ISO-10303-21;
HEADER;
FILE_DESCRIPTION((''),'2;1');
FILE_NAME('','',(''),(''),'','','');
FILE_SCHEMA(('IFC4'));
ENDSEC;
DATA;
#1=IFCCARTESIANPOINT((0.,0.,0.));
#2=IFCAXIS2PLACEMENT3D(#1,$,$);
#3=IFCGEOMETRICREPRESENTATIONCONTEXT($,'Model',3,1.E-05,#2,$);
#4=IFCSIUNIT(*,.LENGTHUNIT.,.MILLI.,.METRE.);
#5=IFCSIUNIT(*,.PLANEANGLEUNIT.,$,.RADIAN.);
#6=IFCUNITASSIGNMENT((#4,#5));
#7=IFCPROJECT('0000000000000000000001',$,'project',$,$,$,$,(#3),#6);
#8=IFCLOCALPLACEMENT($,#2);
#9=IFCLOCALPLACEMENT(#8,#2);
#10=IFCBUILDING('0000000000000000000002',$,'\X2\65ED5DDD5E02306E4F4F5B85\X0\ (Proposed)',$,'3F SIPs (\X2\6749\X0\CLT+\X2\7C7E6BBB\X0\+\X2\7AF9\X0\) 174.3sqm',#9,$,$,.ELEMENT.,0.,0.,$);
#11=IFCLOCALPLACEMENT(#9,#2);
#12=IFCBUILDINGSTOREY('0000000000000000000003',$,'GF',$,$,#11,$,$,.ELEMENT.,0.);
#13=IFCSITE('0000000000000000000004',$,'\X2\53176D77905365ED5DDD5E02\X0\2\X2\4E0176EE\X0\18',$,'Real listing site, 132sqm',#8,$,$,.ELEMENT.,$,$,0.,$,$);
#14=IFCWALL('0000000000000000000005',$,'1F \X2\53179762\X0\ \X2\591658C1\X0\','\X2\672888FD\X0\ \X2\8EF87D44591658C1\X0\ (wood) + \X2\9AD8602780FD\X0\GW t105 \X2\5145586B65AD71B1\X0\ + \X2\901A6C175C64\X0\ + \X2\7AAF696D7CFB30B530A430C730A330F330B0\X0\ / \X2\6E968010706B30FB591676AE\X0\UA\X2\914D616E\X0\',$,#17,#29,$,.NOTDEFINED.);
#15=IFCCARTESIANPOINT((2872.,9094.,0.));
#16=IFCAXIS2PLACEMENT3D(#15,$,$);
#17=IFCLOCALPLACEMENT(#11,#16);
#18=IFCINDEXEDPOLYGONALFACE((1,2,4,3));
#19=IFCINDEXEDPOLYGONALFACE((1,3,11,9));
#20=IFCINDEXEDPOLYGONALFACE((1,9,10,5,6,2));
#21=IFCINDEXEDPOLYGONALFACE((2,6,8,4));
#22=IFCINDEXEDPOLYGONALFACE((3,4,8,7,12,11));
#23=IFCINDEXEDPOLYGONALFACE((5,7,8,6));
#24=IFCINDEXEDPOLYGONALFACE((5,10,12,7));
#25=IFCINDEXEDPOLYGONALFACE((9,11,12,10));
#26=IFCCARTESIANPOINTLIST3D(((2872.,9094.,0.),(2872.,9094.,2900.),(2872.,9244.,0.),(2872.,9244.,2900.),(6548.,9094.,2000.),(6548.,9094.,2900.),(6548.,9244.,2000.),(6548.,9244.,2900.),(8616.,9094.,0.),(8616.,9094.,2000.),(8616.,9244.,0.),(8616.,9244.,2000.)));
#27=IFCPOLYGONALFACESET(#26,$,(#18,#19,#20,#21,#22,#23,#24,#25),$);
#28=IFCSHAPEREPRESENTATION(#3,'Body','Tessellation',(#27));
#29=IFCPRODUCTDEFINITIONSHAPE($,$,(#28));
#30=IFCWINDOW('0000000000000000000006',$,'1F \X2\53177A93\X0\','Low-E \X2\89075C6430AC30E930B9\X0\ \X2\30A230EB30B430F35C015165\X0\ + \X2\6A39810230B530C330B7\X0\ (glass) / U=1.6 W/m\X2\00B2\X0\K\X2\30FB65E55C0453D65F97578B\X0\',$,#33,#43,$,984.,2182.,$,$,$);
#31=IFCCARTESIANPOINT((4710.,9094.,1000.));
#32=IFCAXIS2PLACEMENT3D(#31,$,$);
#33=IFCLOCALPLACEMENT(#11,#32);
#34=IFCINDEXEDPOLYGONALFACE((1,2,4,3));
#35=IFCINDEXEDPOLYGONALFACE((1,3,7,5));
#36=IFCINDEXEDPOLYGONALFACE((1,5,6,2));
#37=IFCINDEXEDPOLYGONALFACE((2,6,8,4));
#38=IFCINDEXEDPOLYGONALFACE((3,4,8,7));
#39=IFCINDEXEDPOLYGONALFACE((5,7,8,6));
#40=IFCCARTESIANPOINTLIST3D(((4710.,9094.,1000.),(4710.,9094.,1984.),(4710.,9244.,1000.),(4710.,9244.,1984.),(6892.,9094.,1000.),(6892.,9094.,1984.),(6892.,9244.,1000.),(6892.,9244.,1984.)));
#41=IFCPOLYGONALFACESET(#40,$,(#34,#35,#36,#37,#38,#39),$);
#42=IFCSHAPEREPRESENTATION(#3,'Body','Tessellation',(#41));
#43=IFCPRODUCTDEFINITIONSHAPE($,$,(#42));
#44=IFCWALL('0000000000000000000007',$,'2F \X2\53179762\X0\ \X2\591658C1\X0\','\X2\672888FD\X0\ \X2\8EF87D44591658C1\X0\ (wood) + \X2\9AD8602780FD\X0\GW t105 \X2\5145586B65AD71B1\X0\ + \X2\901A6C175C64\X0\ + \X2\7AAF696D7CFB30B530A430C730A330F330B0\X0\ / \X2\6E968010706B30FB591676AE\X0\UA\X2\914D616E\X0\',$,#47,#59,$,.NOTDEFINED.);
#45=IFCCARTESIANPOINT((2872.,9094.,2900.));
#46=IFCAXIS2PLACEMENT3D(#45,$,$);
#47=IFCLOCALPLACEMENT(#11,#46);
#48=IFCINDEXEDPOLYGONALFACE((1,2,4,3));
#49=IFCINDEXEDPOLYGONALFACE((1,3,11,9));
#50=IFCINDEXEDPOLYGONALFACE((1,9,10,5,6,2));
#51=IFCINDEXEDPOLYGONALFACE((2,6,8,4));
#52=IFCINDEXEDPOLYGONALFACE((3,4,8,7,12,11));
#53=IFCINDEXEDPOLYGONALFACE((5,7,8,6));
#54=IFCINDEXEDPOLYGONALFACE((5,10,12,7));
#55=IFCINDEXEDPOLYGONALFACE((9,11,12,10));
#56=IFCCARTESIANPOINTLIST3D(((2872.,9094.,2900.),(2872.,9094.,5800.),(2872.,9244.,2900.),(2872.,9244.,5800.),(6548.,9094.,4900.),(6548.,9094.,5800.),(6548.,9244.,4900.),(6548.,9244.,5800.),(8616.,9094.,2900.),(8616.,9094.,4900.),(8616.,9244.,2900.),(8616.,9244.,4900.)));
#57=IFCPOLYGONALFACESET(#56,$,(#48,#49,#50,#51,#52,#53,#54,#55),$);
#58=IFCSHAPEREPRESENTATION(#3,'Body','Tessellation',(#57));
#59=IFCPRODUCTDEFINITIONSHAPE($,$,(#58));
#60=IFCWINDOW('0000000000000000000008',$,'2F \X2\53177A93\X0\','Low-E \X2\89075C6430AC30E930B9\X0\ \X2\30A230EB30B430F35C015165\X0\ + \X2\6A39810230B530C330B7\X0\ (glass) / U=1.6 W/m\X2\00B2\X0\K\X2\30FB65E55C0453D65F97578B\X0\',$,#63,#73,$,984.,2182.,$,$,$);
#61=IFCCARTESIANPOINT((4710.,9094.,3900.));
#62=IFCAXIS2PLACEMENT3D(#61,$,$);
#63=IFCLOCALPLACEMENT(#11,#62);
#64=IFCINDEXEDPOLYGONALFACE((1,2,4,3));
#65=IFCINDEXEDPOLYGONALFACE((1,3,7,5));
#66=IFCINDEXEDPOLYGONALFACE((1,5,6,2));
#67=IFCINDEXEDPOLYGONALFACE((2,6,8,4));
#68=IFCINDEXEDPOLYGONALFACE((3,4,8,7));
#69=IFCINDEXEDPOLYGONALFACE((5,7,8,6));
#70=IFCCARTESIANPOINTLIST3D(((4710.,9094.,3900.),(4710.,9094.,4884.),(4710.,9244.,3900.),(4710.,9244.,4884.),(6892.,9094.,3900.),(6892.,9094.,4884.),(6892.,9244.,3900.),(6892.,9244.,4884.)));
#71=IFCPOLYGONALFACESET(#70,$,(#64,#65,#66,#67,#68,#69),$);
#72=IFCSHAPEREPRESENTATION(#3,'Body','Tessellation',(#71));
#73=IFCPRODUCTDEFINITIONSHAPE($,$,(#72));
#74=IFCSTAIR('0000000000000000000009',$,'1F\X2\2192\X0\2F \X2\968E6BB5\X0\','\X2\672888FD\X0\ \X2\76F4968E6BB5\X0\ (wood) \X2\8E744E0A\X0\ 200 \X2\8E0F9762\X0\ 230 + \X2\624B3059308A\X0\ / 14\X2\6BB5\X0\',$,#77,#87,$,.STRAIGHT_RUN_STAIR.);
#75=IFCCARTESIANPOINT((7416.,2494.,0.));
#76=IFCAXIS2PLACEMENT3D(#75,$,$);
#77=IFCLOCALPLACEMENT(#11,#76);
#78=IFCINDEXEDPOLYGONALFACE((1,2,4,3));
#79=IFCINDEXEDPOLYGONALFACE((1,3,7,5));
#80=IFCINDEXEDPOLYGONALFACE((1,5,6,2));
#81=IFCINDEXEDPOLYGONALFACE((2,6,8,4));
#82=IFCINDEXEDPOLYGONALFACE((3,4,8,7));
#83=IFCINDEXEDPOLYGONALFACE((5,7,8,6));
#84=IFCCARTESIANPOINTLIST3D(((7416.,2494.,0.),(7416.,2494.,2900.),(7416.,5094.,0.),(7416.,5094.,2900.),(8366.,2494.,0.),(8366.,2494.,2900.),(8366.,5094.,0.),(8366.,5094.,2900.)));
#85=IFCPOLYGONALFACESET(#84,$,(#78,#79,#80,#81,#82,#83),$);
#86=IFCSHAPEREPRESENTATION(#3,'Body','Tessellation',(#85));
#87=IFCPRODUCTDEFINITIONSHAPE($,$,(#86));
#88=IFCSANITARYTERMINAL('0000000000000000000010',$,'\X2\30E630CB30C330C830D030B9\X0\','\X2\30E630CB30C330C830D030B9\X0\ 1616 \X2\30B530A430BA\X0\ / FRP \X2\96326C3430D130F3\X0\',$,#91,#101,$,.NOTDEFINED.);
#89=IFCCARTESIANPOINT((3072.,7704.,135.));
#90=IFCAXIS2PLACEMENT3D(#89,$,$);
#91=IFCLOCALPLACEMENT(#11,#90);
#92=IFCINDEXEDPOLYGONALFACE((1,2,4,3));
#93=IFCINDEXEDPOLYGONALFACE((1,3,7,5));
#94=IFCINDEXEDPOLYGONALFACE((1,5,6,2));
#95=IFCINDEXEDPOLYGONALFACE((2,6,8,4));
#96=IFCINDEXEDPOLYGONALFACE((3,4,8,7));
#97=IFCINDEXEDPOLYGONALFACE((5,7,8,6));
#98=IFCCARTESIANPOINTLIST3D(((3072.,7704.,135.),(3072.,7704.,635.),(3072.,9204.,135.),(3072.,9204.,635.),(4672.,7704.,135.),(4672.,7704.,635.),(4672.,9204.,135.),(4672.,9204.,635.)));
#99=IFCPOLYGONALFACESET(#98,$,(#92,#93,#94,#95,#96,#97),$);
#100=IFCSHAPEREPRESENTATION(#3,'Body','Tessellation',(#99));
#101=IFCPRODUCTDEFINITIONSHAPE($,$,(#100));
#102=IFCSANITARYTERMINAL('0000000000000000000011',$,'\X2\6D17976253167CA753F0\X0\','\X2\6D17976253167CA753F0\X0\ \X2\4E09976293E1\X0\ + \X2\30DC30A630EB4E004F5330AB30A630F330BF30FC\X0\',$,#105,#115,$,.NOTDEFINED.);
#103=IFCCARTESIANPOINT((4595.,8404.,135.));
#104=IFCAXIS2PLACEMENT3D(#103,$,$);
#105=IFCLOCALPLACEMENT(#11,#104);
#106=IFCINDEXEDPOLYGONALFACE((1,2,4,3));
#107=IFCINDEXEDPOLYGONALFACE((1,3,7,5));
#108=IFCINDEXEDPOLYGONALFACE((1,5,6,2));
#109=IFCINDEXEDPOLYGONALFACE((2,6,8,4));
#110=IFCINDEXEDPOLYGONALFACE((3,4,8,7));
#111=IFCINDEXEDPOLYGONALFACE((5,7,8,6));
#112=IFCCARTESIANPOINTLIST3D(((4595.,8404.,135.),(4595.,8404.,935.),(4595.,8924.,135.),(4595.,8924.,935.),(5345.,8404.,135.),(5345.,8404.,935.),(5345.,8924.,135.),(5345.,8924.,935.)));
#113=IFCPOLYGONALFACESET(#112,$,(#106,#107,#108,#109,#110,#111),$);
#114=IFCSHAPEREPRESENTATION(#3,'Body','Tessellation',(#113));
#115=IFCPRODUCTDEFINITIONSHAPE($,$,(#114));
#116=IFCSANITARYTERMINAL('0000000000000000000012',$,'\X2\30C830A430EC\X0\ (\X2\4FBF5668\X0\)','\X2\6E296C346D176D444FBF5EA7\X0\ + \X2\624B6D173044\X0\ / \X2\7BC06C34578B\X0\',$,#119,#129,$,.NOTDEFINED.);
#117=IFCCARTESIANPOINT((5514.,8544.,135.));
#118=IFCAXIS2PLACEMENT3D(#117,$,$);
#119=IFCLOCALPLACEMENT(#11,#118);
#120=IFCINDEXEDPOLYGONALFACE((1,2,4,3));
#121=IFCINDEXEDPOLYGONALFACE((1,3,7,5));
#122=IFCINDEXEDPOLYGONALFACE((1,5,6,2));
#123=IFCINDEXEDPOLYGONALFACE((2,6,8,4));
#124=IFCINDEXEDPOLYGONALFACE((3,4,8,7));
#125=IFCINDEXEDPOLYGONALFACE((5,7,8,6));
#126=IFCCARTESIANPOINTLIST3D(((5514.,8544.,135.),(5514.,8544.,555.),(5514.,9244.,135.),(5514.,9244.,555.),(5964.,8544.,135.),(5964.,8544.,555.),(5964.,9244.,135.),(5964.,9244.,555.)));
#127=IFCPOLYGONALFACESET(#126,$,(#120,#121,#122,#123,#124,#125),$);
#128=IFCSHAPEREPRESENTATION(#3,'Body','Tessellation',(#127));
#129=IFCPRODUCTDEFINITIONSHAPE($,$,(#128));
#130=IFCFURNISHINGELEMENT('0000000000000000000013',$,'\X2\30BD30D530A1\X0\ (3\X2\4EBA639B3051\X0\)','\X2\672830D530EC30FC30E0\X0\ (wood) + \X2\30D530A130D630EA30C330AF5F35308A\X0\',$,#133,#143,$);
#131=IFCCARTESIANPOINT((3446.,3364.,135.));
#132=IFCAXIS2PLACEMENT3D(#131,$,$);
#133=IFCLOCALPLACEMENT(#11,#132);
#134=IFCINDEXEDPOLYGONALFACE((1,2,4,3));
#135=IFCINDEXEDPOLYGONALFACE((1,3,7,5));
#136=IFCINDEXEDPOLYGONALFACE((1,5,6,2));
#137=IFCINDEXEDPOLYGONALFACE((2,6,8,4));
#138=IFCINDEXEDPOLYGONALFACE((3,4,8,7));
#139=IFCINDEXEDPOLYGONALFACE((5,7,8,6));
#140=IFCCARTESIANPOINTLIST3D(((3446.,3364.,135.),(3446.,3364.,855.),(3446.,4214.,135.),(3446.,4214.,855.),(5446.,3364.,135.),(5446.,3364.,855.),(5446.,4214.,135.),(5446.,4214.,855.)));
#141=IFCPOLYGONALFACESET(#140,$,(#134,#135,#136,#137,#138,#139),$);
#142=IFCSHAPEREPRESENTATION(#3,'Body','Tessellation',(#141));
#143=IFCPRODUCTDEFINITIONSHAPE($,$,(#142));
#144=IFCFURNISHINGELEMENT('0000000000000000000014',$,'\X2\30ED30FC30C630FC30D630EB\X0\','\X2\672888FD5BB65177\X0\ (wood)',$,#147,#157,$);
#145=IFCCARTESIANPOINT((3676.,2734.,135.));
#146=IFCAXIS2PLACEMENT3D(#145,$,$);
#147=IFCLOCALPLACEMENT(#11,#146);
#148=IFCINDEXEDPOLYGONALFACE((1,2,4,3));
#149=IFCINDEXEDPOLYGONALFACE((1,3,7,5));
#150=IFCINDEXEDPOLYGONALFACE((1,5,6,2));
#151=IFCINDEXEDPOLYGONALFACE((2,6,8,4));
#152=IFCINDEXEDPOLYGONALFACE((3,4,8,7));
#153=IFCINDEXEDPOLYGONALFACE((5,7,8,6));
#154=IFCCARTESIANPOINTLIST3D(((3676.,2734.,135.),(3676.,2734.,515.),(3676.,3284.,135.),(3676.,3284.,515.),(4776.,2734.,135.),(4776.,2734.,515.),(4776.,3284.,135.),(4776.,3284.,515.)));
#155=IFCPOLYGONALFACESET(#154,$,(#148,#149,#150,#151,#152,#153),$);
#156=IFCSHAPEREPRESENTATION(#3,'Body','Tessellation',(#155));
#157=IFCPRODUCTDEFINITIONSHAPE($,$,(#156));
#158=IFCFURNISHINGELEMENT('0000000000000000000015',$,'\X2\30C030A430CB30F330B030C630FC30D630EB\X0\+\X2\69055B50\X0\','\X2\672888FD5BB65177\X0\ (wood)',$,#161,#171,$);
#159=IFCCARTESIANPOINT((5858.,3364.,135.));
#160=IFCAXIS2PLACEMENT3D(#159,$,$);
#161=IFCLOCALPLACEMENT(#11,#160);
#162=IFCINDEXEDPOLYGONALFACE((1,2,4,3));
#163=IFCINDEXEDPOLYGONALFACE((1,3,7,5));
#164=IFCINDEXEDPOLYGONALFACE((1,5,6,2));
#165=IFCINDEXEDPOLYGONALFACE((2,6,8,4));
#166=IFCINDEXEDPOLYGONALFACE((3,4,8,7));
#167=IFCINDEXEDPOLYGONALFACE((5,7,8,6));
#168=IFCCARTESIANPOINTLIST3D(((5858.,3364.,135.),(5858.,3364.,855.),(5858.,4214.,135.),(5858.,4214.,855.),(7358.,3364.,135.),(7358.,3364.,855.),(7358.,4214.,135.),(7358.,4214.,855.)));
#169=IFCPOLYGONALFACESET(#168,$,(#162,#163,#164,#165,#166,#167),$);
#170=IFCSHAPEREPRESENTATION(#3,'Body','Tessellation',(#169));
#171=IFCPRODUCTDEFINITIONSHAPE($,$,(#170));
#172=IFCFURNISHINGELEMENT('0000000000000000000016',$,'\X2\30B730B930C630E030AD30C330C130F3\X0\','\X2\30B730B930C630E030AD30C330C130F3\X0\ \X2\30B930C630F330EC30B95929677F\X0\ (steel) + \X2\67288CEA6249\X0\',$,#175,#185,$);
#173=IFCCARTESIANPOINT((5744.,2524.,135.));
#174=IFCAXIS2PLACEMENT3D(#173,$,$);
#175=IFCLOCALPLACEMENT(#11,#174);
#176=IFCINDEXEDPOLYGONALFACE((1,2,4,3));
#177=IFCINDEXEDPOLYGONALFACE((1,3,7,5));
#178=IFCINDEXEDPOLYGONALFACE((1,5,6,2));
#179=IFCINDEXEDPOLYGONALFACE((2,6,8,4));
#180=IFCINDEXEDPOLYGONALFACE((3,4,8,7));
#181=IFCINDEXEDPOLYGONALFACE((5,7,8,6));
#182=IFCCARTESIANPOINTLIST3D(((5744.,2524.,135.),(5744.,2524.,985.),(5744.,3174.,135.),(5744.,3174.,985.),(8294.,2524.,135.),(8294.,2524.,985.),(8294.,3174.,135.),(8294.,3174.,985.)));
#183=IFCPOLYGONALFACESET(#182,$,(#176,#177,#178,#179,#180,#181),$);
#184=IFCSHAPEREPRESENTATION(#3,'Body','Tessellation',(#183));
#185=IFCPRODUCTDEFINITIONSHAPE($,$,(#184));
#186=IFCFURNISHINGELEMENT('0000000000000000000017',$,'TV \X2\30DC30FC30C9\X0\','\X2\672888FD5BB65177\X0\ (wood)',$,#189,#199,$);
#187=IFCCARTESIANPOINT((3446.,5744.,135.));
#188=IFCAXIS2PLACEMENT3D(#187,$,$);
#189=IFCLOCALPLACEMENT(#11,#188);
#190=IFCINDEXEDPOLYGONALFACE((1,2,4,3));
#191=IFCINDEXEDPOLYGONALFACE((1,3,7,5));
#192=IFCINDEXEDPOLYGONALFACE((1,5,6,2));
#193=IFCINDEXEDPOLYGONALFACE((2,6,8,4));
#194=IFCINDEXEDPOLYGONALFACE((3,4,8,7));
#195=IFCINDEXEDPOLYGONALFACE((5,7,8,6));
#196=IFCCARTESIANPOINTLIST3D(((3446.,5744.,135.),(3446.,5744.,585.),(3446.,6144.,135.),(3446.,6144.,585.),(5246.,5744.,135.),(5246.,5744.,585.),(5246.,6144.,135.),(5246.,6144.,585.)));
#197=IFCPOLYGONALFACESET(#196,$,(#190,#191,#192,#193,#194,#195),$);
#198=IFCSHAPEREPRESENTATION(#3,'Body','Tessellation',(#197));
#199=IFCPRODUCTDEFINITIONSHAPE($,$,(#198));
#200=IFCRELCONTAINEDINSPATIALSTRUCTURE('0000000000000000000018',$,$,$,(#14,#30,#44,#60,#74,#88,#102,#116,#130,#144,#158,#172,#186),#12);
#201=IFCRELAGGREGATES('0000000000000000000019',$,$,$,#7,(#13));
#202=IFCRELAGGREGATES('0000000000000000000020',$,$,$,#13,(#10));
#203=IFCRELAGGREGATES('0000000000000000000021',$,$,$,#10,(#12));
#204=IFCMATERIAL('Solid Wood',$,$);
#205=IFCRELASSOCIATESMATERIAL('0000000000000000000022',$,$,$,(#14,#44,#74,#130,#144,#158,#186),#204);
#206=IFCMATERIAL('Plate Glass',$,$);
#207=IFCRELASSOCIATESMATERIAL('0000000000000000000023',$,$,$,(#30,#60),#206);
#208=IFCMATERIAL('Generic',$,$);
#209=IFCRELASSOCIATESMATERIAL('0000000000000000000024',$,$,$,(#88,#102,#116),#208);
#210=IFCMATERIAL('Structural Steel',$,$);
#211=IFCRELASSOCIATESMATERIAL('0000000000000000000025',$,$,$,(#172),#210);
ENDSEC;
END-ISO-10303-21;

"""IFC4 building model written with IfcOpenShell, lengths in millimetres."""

from ifc_helpers import new_model, si_unit, frame, frame_2d, origin, place, context, project, spatial, rectangle, extrude, material, element, fill, save


model = new_model("IFC4")

# Units and contexts
model_context = context("Model", 3, precision=1e-05, world=origin())
ifc_project = project(units=[si_unit("LENGTHUNIT", "METRE", prefix="MILLI"), si_unit("PLANEANGLEUNIT", "RADIAN")], contexts=[model_context])

# Site, building, storey
site_placement = place(None, origin())
site = spatial("IfcSite", under=ifc_project, at=site_placement, Name="北海道旭川市2丁目18", ObjectType="Real listing site, 132sqm", CompositionType="ELEMENT", RefElevation=0.0)
building_placement = place(site_placement, origin())
building = spatial("IfcBuilding", under=site, at=building_placement, Name="旭川市の住宅 (Proposed)", ObjectType="3F SIPs (杉CLT+籾殻+竹) 174.3sqm", CompositionType="ELEMENT", ElevationOfRefHeight=0.0, ElevationOfTerrain=0.0)
storey_placement = place(building_placement, origin())
storey = spatial("IfcBuildingStorey", under=building, at=storey_placement, Name="GF", CompositionType="ELEMENT", Elevation=0.0)

# Wall, opening, window
ifc_material_1 = material(Name="Solid Wood")
wall_1_placement = place(storey_placement, frame((2872.0, 9094.0, 0.0)))
wall_1 = element("IfcWall", 1, at=wall_1_placement, inside=storey, material=ifc_material_1, Name="1F 北面 外壁", Description="木製 軸組外壁 (wood) + 高性能GW t105 充填断熱 + 通気層 + 窯業系サイディング / 準耐火・外皮UA配慮", PredefinedType="NOTDEFINED", context=model_context, shape_type="SweptSolid", body=[
    extrude(rectangle(XDim=5744.0, YDim=150.0, at=frame_2d((2872.0, 75.0))), frame((2872.0, 9094.0, 0.0)), (0.0, 0.0, 1.0), 2900.0),
])
opening_1_placement = place(storey_placement, frame((4710.0, 9094.0, 1000.0)))
opening_1 = element("IfcOpeningElement", 2, at=opening_1_placement, cuts=wall_1, PredefinedType="NOTDEFINED", context=model_context, shape_type="SweptSolid", body=[
    extrude(rectangle(XDim=2182.0, YDim=150.0, at=frame_2d((1091.0, 75.0))), frame((4710.0, 9094.0, 1000.0)), (0.0, 0.0, 1.0), 984.0),
])
ifc_material_2 = material(Name="Plate Glass")
window_1_placement = place(storey_placement, frame((4710.0, 9094.0, 1000.0)))
window_1 = element("IfcWindow", 3, at=window_1_placement, inside=storey, material=ifc_material_2, Name="1F 北窓", Description="Low-E 複層ガラス アルゴン封入 + 樹脂サッシ (glass) / U=1.6 W/m²K・日射取得型", OverallHeight=984.0, OverallWidth=2182.0, context=model_context, shape_type="SweptSolid", body=[
    extrude(rectangle(XDim=2182.0, YDim=150.0, at=frame_2d((1091.0, 75.0))), frame((4710.0, 9094.0, 1000.0)), (0.0, 0.0, 1.0), 984.0),
])
fill(opening_1, window_1)

# Wall, opening, window
wall_2_placement = place(storey_placement, frame((2872.0, 9094.0, 2900.0)))
wall_2 = element("IfcWall", 4, at=wall_2_placement, inside=storey, material=ifc_material_1, Name="2F 北面 外壁", Description="木製 軸組外壁 (wood) + 高性能GW t105 充填断熱 + 通気層 + 窯業系サイディング / 準耐火・外皮UA配慮", PredefinedType="NOTDEFINED", context=model_context, shape_type="SweptSolid", body=[
    extrude(rectangle(XDim=5744.0, YDim=150.0, at=frame_2d((2872.0, 75.0))), frame((2872.0, 9094.0, 2900.0)), (0.0, 0.0, 1.0), 2900.0),
])
opening_2_placement = place(storey_placement, frame((4710.0, 9094.0, 3900.0)))
opening_2 = element("IfcOpeningElement", 5, at=opening_2_placement, cuts=wall_2, PredefinedType="NOTDEFINED", context=model_context, shape_type="SweptSolid", body=[
    extrude(rectangle(XDim=2182.0, YDim=150.0, at=frame_2d((1091.0, 75.0))), frame((4710.0, 9094.0, 3900.0)), (0.0, 0.0, 1.0), 984.0),
])
window_2_placement = place(storey_placement, frame((4710.0, 9094.0, 3900.0)))
window_2 = element("IfcWindow", 6, at=window_2_placement, inside=storey, material=ifc_material_2, Name="2F 北窓", Description="Low-E 複層ガラス アルゴン封入 + 樹脂サッシ (glass) / U=1.6 W/m²K・日射取得型", OverallHeight=984.0, OverallWidth=2182.0, context=model_context, shape_type="SweptSolid", body=[
    extrude(rectangle(XDim=2182.0, YDim=150.0, at=frame_2d((1091.0, 75.0))), frame((4710.0, 9094.0, 3900.0)), (0.0, 0.0, 1.0), 984.0),
])
fill(opening_2, window_2)

# Stair
stair_placement = place(storey_placement, frame((7416.0, 2494.0, 0.0)))
element("IfcStair", 7, at=stair_placement, inside=storey, material=ifc_material_1, Name="1F→2F 階段", Description="木製 直階段 (wood) 蹴上 200 踏面 230 + 手すり / 14段", PredefinedType="STRAIGHT_RUN_STAIR", context=model_context, shape_type="SweptSolid", body=[
    extrude(rectangle(XDim=950.0, YDim=2600.0, at=frame_2d((475.0, 1300.0))), frame((7416.0, 2494.0, 0.0)), (0.0, 0.0, 1.0), 2900.0),
])

# Sanitary terminals
ifc_material_3 = material(Name="Generic")
sanitary_terminal_1_placement = place(storey_placement, frame((3072.0, 7704.0, 135.0)))
element("IfcSanitaryTerminal", 8, at=sanitary_terminal_1_placement, inside=storey, material=ifc_material_3, Name="ユニットバス", Description="ユニットバス 1616 サイズ / FRP 防水パン", PredefinedType="NOTDEFINED", context=model_context, shape_type="SweptSolid", body=[
    extrude(rectangle(XDim=1600.0, YDim=1500.0, at=frame_2d((800.0, 750.0))), frame((3072.0, 7704.0, 135.0)), (0.0, 0.0, 1.0), 500.0),
])
sanitary_terminal_2_placement = place(storey_placement, frame((4595.0, 8404.0, 135.0)))
element("IfcSanitaryTerminal", 9, at=sanitary_terminal_2_placement, inside=storey, material=ifc_material_3, Name="洗面化粧台", Description="洗面化粧台 三面鏡 + ボウル一体カウンター", PredefinedType="NOTDEFINED", context=model_context, shape_type="SweptSolid", body=[
    extrude(rectangle(XDim=750.0, YDim=520.0, at=frame_2d((375.0, 260.0))), frame((4595.0, 8404.0, 135.0)), (0.0, 0.0, 1.0), 800.0),
])
sanitary_terminal_3_placement = place(storey_placement, frame((5514.0, 8544.0, 135.0)))
element("IfcSanitaryTerminal", 10, at=sanitary_terminal_3_placement, inside=storey, material=ifc_material_3, Name="トイレ (便器)", Description="温水洗浄便座 + 手洗い / 節水型", PredefinedType="NOTDEFINED", context=model_context, shape_type="SweptSolid", body=[
    extrude(rectangle(XDim=450.0, YDim=700.0, at=frame_2d((225.0, 350.0))), frame((5514.0, 8544.0, 135.0)), (0.0, 0.0, 1.0), 420.0),
])

# Furnishing elements
furnishing_1_placement = place(storey_placement, frame((3446.0, 3364.0, 135.0)))
element("IfcFurnishingElement", 11, at=furnishing_1_placement, inside=storey, material=ifc_material_1, Name="ソファ (3人掛け)", Description="木フレーム (wood) + ファブリック張り", context=model_context, shape_type="SweptSolid", body=[
    extrude(rectangle(XDim=2000.0, YDim=850.0, at=frame_2d((1000.0, 425.0))), frame((3446.0, 3364.0, 135.0)), (0.0, 0.0, 1.0), 720.0),
])
furnishing_2_placement = place(storey_placement, frame((3676.0, 2734.0, 135.0)))
element("IfcFurnishingElement", 12, at=furnishing_2_placement, inside=storey, material=ifc_material_1, Name="ローテーブル", Description="木製家具 (wood)", context=model_context, shape_type="SweptSolid", body=[
    extrude(rectangle(XDim=1100.0, YDim=550.0, at=frame_2d((550.0, 275.0))), frame((3676.0, 2734.0, 135.0)), (0.0, 0.0, 1.0), 380.0),
])
furnishing_3_placement = place(storey_placement, frame((5858.0, 3364.0, 135.0)))
element("IfcFurnishingElement", 13, at=furnishing_3_placement, inside=storey, material=ifc_material_1, Name="ダイニングテーブル+椅子", Description="木製家具 (wood)", context=model_context, shape_type="SweptSolid", body=[
    extrude(rectangle(XDim=1500.0, YDim=850.0, at=frame_2d((750.0, 425.0))), frame((5858.0, 3364.0, 135.0)), (0.0, 0.0, 1.0), 720.0),
])
ifc_material_4 = material(Name="Structural Steel")
furnishing_4_placement = place(storey_placement, frame((5744.0, 2524.0, 135.0)))
element("IfcFurnishingElement", 14, at=furnishing_4_placement, inside=storey, material=ifc_material_4, Name="システムキッチン", Description="システムキッチン ステンレス天板 (steel) + 木質扉", context=model_context, shape_type="SweptSolid", body=[
    extrude(rectangle(XDim=2550.0, YDim=650.0, at=frame_2d((1275.0, 325.0))), frame((5744.0, 2524.0, 135.0)), (0.0, 0.0, 1.0), 850.0),
])
furnishing_5_placement = place(storey_placement, frame((3446.0, 5744.0, 135.0)))
element("IfcFurnishingElement", 15, at=furnishing_5_placement, inside=storey, material=ifc_material_1, Name="TV ボード", Description="木製家具 (wood)", context=model_context, shape_type="SweptSolid", body=[
    extrude(rectangle(XDim=1800.0, YDim=400.0, at=frame_2d((900.0, 200.0))), frame((3446.0, 5744.0, 135.0)), (0.0, 0.0, 1.0), 450.0),
])

save(model, "model.ifc")
